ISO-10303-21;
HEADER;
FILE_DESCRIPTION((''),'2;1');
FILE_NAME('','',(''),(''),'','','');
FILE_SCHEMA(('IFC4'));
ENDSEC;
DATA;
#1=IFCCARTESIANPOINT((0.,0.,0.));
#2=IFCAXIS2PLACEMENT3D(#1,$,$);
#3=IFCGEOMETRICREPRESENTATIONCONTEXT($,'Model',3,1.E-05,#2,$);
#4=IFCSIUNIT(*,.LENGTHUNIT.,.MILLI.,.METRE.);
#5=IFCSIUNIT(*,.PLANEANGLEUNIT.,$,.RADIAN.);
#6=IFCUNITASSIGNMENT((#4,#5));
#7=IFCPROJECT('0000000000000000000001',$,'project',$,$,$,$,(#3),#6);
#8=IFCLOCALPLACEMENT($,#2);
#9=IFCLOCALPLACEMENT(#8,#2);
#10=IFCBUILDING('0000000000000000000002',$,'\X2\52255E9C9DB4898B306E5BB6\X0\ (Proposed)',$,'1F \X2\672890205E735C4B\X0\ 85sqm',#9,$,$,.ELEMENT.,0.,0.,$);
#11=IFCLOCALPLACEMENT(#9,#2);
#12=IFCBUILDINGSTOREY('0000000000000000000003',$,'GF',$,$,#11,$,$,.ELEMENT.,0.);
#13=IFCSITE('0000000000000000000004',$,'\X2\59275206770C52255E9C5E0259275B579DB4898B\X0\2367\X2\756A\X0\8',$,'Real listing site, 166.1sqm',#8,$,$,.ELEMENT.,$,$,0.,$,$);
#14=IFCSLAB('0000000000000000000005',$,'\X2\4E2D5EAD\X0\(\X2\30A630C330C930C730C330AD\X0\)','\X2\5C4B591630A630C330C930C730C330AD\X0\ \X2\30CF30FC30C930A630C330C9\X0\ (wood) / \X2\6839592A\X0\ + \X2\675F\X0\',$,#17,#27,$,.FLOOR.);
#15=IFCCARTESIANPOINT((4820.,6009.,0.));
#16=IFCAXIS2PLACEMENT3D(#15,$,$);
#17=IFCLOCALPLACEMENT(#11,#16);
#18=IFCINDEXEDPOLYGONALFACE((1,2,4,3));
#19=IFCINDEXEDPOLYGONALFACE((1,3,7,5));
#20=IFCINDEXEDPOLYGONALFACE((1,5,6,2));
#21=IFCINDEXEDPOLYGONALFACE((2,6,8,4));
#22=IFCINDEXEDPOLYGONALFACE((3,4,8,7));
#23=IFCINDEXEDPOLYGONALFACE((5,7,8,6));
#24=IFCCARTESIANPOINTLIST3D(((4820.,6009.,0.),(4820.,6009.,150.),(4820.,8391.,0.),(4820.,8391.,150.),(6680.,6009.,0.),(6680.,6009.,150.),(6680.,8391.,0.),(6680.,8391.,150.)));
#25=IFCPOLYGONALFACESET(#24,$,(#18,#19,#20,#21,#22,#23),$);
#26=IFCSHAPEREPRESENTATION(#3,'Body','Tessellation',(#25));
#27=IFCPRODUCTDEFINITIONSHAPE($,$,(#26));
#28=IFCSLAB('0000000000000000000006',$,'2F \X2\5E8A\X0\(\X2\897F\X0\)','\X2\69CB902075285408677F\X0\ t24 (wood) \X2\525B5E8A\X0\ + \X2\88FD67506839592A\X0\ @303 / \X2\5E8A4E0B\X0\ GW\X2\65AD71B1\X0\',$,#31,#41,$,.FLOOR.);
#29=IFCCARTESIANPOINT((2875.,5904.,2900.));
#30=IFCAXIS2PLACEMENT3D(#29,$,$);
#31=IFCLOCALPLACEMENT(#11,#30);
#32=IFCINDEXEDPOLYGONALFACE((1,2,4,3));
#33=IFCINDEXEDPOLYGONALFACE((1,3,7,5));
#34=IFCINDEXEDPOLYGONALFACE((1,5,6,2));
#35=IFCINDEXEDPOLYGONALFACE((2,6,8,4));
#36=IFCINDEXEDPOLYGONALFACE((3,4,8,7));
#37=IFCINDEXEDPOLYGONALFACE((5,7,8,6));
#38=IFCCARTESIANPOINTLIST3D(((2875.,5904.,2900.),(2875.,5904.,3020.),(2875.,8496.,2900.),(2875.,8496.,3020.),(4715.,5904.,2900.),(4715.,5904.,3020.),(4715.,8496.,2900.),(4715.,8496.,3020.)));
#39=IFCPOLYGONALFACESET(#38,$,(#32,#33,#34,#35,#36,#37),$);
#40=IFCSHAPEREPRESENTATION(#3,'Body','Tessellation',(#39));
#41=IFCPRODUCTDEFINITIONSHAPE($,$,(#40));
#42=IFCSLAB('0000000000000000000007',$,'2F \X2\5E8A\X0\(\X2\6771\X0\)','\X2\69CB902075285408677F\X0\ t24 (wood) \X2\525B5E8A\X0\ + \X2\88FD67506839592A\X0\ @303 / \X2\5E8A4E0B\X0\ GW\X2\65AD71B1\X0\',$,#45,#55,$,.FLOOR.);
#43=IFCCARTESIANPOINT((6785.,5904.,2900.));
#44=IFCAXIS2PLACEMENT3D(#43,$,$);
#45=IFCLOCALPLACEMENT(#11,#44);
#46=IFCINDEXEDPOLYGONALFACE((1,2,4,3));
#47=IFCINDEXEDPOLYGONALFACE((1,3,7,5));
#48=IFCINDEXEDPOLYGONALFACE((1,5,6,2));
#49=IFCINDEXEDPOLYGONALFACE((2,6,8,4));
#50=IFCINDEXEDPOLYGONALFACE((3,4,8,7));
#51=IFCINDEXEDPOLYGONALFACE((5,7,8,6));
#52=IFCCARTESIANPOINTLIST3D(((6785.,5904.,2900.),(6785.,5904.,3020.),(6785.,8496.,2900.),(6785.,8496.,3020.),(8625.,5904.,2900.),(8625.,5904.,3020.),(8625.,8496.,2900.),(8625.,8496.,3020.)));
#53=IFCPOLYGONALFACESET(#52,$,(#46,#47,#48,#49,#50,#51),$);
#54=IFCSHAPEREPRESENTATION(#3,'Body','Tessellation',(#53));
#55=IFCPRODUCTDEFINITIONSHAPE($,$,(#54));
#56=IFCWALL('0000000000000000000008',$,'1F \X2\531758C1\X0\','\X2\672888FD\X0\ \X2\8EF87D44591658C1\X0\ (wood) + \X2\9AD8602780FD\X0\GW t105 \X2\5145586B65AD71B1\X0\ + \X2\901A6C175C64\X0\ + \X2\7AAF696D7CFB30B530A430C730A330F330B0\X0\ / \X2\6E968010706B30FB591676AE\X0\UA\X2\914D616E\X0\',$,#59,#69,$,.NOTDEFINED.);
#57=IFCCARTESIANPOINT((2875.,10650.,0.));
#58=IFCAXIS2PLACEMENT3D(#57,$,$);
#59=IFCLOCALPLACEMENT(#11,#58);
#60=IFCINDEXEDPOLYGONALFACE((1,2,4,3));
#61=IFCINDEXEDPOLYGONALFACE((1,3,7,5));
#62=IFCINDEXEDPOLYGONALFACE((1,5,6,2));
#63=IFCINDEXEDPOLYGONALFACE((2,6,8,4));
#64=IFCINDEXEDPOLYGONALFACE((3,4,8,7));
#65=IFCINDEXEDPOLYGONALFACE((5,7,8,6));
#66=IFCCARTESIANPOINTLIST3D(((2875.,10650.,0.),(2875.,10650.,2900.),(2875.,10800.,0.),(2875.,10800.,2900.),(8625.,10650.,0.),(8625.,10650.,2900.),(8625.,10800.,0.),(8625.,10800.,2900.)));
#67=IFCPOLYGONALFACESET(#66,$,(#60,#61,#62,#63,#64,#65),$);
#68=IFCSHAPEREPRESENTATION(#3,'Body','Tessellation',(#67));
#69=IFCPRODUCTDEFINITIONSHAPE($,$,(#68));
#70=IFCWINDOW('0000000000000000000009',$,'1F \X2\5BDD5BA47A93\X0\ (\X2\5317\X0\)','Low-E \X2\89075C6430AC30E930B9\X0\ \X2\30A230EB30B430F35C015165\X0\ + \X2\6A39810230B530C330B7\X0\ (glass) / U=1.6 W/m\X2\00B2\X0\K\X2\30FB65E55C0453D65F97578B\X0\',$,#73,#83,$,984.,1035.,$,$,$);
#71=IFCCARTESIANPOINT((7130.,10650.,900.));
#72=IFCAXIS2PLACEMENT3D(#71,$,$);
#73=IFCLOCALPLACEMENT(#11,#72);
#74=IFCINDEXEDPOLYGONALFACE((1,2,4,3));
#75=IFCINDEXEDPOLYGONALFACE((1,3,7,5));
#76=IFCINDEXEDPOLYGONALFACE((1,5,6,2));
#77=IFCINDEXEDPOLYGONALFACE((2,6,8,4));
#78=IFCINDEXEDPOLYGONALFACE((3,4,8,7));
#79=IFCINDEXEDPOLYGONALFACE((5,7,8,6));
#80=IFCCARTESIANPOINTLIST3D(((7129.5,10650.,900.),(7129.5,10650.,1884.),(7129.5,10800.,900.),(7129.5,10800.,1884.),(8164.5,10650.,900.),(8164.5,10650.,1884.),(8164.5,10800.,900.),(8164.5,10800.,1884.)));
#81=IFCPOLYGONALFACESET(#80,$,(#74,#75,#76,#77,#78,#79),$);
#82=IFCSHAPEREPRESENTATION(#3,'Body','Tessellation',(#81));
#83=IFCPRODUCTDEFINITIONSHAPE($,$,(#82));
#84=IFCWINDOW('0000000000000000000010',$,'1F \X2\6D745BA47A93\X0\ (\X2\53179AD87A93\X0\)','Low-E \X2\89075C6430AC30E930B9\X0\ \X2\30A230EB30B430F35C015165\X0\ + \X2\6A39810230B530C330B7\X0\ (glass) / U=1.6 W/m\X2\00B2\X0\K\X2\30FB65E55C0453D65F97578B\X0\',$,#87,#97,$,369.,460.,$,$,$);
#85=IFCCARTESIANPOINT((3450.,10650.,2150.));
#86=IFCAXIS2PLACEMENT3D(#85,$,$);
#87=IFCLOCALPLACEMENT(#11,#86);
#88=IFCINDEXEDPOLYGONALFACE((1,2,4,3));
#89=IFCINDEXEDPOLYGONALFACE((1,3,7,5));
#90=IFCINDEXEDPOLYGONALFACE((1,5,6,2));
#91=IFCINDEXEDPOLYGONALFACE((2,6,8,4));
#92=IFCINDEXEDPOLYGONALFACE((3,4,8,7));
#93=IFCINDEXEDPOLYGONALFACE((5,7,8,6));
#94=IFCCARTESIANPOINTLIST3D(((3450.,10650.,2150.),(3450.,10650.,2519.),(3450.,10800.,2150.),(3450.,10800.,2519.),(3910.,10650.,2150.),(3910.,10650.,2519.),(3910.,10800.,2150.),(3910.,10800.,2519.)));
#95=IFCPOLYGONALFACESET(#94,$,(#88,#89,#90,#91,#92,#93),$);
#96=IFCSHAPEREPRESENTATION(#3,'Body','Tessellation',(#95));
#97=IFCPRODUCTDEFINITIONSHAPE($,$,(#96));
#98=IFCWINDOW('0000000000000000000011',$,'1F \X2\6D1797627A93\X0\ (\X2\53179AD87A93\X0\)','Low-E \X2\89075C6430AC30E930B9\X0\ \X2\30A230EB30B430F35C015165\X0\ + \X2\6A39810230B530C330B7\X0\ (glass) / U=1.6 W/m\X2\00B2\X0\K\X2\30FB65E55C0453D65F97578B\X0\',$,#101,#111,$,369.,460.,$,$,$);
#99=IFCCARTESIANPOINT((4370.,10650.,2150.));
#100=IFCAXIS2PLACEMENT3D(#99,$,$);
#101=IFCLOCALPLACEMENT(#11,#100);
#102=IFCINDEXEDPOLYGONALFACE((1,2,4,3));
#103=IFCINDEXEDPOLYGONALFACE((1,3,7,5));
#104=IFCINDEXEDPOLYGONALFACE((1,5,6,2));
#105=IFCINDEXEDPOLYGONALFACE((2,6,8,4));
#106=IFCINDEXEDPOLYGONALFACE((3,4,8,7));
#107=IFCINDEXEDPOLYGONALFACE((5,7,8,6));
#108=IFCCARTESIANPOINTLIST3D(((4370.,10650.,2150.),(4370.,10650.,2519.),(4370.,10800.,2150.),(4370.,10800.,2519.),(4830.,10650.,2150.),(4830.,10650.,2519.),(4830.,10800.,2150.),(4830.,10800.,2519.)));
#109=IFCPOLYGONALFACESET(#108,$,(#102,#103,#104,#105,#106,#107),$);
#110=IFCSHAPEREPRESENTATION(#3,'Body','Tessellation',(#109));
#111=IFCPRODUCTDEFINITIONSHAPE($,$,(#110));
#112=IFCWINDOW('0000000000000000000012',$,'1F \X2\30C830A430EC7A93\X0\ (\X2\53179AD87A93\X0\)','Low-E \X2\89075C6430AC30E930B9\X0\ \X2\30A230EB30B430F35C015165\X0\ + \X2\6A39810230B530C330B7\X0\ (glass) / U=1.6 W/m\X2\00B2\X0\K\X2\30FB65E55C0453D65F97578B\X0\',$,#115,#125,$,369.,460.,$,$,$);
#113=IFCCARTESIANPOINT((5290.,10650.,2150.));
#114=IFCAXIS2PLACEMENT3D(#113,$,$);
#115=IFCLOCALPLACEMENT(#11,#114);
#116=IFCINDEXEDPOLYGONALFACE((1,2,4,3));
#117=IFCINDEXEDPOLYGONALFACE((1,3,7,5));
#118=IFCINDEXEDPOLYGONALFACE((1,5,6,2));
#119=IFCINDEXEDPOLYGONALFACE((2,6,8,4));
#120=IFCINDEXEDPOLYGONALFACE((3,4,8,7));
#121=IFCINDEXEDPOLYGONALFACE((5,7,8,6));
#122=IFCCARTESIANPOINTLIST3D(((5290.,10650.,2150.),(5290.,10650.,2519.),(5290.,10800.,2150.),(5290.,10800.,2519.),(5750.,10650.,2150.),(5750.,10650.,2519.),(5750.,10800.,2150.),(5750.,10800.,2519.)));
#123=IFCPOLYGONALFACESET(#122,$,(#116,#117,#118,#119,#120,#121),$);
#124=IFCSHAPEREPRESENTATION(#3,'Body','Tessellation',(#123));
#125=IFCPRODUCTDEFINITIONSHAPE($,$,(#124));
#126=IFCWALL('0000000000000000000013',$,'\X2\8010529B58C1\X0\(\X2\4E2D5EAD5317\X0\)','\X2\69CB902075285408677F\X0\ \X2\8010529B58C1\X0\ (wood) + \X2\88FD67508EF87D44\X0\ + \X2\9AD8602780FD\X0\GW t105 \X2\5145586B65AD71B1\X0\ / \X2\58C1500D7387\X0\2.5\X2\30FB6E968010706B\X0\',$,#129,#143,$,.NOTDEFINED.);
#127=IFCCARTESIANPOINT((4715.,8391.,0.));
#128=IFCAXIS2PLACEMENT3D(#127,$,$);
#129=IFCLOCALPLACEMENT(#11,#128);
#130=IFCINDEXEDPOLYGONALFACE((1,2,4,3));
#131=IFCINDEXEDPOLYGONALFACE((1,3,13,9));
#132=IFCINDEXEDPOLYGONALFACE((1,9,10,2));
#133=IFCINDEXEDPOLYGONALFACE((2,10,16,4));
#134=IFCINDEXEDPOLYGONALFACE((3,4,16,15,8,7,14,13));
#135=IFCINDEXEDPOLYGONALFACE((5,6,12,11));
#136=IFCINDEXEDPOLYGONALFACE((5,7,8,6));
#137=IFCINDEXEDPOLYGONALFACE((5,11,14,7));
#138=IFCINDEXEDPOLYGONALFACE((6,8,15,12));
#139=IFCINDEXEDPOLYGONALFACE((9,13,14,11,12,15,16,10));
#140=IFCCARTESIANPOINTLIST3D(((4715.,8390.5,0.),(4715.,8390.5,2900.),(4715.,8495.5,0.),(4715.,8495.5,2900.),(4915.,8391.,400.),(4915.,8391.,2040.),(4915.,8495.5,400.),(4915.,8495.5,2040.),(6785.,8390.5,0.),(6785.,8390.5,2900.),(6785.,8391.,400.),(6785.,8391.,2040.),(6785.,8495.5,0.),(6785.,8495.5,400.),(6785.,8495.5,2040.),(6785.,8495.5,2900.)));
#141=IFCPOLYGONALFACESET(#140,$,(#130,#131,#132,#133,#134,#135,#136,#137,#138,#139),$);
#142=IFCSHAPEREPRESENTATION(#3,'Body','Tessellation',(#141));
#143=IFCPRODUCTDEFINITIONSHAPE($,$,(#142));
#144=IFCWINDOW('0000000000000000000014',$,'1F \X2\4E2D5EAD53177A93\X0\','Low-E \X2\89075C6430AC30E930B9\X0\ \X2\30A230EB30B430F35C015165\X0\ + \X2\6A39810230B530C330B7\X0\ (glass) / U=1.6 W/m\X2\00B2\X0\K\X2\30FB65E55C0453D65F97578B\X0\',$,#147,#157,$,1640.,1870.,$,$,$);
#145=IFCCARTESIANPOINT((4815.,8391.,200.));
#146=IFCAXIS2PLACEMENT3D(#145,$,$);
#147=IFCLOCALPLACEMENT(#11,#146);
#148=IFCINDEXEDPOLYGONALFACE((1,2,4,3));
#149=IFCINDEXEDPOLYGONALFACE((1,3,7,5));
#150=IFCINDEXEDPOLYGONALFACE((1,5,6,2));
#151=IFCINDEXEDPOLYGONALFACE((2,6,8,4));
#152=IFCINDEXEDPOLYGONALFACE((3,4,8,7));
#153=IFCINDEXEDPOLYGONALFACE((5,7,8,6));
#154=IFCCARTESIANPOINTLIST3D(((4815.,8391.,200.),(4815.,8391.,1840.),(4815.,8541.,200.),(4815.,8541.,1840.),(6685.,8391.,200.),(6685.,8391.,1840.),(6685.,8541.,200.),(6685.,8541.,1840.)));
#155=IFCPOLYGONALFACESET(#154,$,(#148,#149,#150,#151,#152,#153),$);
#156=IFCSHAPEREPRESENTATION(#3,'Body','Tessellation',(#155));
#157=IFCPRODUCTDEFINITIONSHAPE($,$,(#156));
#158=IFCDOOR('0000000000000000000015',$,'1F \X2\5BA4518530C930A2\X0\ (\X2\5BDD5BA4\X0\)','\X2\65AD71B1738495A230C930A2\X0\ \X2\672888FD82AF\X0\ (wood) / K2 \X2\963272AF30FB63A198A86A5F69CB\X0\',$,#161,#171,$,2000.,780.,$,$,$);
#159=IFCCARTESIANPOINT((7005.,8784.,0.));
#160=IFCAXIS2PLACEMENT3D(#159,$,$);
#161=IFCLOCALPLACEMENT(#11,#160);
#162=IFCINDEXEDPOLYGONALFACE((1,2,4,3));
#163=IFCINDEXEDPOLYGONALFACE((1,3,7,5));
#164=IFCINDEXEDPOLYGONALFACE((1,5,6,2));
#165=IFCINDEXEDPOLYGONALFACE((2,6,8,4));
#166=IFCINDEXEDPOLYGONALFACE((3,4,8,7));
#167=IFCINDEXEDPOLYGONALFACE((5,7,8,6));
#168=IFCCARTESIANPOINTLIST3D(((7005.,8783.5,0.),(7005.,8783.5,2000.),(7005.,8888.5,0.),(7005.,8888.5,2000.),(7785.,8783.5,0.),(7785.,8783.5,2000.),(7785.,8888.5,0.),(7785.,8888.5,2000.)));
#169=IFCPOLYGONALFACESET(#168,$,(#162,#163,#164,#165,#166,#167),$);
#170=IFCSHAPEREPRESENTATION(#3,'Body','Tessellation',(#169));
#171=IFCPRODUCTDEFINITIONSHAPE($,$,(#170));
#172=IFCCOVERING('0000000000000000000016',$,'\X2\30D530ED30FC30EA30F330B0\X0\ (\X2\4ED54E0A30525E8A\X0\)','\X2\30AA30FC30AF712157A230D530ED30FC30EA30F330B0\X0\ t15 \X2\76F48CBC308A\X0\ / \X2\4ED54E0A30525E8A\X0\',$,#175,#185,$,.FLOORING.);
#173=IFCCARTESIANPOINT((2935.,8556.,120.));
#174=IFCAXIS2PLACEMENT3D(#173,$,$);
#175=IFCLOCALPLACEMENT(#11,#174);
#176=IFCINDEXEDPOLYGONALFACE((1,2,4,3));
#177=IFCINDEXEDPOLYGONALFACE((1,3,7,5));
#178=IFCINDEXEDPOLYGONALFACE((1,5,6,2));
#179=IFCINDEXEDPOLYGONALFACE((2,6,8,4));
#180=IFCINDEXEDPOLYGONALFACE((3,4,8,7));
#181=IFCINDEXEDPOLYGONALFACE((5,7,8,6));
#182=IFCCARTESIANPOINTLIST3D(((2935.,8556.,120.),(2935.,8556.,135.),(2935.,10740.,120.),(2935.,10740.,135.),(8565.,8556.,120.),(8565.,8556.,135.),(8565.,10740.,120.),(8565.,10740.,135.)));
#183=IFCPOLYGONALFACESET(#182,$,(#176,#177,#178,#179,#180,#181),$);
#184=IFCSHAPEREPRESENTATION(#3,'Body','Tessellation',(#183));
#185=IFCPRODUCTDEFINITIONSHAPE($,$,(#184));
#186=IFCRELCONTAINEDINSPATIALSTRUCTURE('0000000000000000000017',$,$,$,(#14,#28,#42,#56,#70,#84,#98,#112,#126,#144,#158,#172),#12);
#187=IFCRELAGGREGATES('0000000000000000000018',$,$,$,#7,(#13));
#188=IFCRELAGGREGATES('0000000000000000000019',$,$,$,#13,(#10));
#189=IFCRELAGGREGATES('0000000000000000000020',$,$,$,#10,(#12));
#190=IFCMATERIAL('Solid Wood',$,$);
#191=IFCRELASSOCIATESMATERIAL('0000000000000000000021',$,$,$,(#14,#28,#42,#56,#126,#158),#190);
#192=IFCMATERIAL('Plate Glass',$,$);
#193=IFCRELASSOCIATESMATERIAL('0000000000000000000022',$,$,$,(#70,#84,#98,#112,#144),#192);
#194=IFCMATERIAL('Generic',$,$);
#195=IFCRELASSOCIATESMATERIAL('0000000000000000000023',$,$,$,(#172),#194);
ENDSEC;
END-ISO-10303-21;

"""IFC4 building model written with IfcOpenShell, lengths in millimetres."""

from ifc_helpers import new_model, si_unit, frame, frame_2d, origin, place, context, project, spatial, rectangle, extrude, material, element, fill, save


model = new_model("IFC4")

# Units and contexts
model_context = context("Model", 3, precision=1e-05, world=origin())
ifc_project = project(units=[si_unit("LENGTHUNIT", "METRE", prefix="MILLI"), si_unit("PLANEANGLEUNIT", "RADIAN")], contexts=[model_context])

# Site, building, storey
site_placement = place(None, origin())
site = spatial("IfcSite", under=ifc_project, at=site_placement, Name="大分県別府市大字鶴見2367番8", ObjectType="Real listing site, 166.1sqm", CompositionType="ELEMENT", RefElevation=0.0)
building_placement = place(site_placement, origin())
building = spatial("IfcBuilding", under=site, at=building_placement, Name="別府鶴見の家 (Proposed)", ObjectType="1F 木造平屋 85sqm", CompositionType="ELEMENT", ElevationOfRefHeight=0.0, ElevationOfTerrain=0.0)
storey_placement = place(building_placement, origin())
storey = spatial("IfcBuildingStorey", under=building, at=storey_placement, Name="GF", CompositionType="ELEMENT", Elevation=0.0)

# Slabs
ifc_material_1 = material(Name="Solid Wood")
slab_1_placement = place(storey_placement, frame((4820.0, 6009.0, 0.0)))
element("IfcSlab", 1, at=slab_1_placement, inside=storey, material=ifc_material_1, Name="中庭(ウッドデッキ)", Description="屋外ウッドデッキ ハードウッド (wood) / 根太 + 束", PredefinedType="FLOOR", context=model_context, shape_type="SweptSolid", body=[
    extrude(rectangle(XDim=1860.0, YDim=2382.0, at=frame_2d((930.0, 1191.0))), frame((4820.0, 6009.0, 0.0)), (0.0, 0.0, 1.0), 150.0),
])
slab_2_placement = place(storey_placement, frame((2875.0, 5904.0, 2900.0)))
element("IfcSlab", 2, at=slab_2_placement, inside=storey, material=ifc_material_1, Name="2F 床(西)", Description="構造用合板 t24 (wood) 剛床 + 製材根太 @303 / 床下 GW断熱", PredefinedType="FLOOR", context=model_context, shape_type="SweptSolid", body=[
    extrude(rectangle(XDim=1840.0, YDim=2592.0, at=frame_2d((920.0, 1296.0))), frame((2875.0, 5904.0, 2900.0)), (0.0, 0.0, 1.0), 120.0),
])
slab_3_placement = place(storey_placement, frame((6785.0, 5904.0, 2900.0)))
element("IfcSlab", 3, at=slab_3_placement, inside=storey, material=ifc_material_1, Name="2F 床(東)", Description="構造用合板 t24 (wood) 剛床 + 製材根太 @303 / 床下 GW断熱", PredefinedType="FLOOR", context=model_context, shape_type="SweptSolid", body=[
    extrude(rectangle(XDim=1840.0, YDim=2592.0, at=frame_2d((920.0, 1296.0))), frame((6785.0, 5904.0, 2900.0)), (0.0, 0.0, 1.0), 120.0),
])

# Wall, openings, windows
wall_1_placement = place(storey_placement, frame((2875.0, 10650.0, 0.0)))
wall_1 = element("IfcWall", 4, at=wall_1_placement, inside=storey, material=ifc_material_1, Name="1F 北壁", Description="木製 軸組外壁 (wood) + 高性能GW t105 充填断熱 + 通気層 + 窯業系サイディング / 準耐火・外皮UA配慮", PredefinedType="NOTDEFINED", context=model_context, shape_type="SweptSolid", body=[
    extrude(rectangle(XDim=5750.0, YDim=150.0, at=frame_2d((2875.0, 75.0))), frame((2875.0, 10650.0, 0.0)), (0.0, 0.0, 1.0), 2900.0),
])
opening_1_placement = place(storey_placement, frame((7130.0, 10650.0, 900.0)))
opening_1 = element("IfcOpeningElement", 5, at=opening_1_placement, cuts=wall_1, PredefinedType="NOTDEFINED", context=model_context, shape_type="SweptSolid", body=[
    extrude(rectangle(XDim=1035.0, YDim=150.0, at=frame_2d((517.0, 75.0))), frame((7130.0, 10650.0, 900.0)), (0.0, 0.0, 1.0), 984.0),
])
opening_2_placement = place(storey_placement, frame((3450.0, 10650.0, 2150.0)))
opening_2 = element("IfcOpeningElement", 6, at=opening_2_placement, cuts=wall_1, PredefinedType="NOTDEFINED", context=model_context, shape_type="SweptSolid", body=[
    extrude(rectangle(XDim=460.0, YDim=150.0, at=frame_2d((230.0, 75.0))), frame((3450.0, 10650.0, 2150.0)), (0.0, 0.0, 1.0), 369.0),
])
opening_3_placement = place(storey_placement, frame((4370.0, 10650.0, 2150.0)))
opening_3 = element("IfcOpeningElement", 7, at=opening_3_placement, cuts=wall_1, PredefinedType="NOTDEFINED", context=model_context, shape_type="SweptSolid", body=[
    extrude(rectangle(XDim=460.0, YDim=150.0, at=frame_2d((230.0, 75.0))), frame((4370.0, 10650.0, 2150.0)), (0.0, 0.0, 1.0), 369.0),
])
opening_4_placement = place(storey_placement, frame((5290.0, 10650.0, 2150.0)))
opening_4 = element("IfcOpeningElement", 8, at=opening_4_placement, cuts=wall_1, PredefinedType="NOTDEFINED", context=model_context, shape_type="SweptSolid", body=[
    extrude(rectangle(XDim=460.0, YDim=150.0, at=frame_2d((230.0, 75.0))), frame((5290.0, 10650.0, 2150.0)), (0.0, 0.0, 1.0), 369.0),
])
ifc_material_2 = material(Name="Plate Glass")
window_1_placement = place(storey_placement, frame((7130.0, 10650.0, 900.0)))
window_1 = element("IfcWindow", 9, at=window_1_placement, inside=storey, material=ifc_material_2, Name="1F 寝室窓 (北)", Description="Low-E 複層ガラス アルゴン封入 + 樹脂サッシ (glass) / U=1.6 W/m²K・日射取得型", OverallHeight=984.0, OverallWidth=1035.0, context=model_context, shape_type="SweptSolid", body=[
    extrude(rectangle(XDim=1035.0, YDim=150.0, at=frame_2d((517.0, 75.0))), frame((7130.0, 10650.0, 900.0)), (0.0, 0.0, 1.0), 984.0),
])
fill(opening_1, window_1)
window_2_placement = place(storey_placement, frame((3450.0, 10650.0, 2150.0)))
window_2 = element("IfcWindow", 10, at=window_2_placement, inside=storey, material=ifc_material_2, Name="1F 浴室窓 (北高窓)", Description="Low-E 複層ガラス アルゴン封入 + 樹脂サッシ (glass) / U=1.6 W/m²K・日射取得型", OverallHeight=369.0, OverallWidth=460.0, context=model_context, shape_type="SweptSolid", body=[
    extrude(rectangle(XDim=460.0, YDim=150.0, at=frame_2d((230.0, 75.0))), frame((3450.0, 10650.0, 2150.0)), (0.0, 0.0, 1.0), 369.0),
])
fill(opening_2, window_2)
window_3_placement = place(storey_placement, frame((4370.0, 10650.0, 2150.0)))
window_3 = element("IfcWindow", 11, at=window_3_placement, inside=storey, material=ifc_material_2, Name="1F 洗面窓 (北高窓)", Description="Low-E 複層ガラス アルゴン封入 + 樹脂サッシ (glass) / U=1.6 W/m²K・日射取得型", OverallHeight=369.0, OverallWidth=460.0, context=model_context, shape_type="SweptSolid", body=[
    extrude(rectangle(XDim=460.0, YDim=150.0, at=frame_2d((230.0, 75.0))), frame((4370.0, 10650.0, 2150.0)), (0.0, 0.0, 1.0), 369.0),
])
fill(opening_3, window_3)
window_4_placement = place(storey_placement, frame((5290.0, 10650.0, 2150.0)))
window_4 = element("IfcWindow", 12, at=window_4_placement, inside=storey, material=ifc_material_2, Name="1F トイレ窓 (北高窓)", Description="Low-E 複層ガラス アルゴン封入 + 樹脂サッシ (glass) / U=1.6 W/m²K・日射取得型", OverallHeight=369.0, OverallWidth=460.0, context=model_context, shape_type="SweptSolid", body=[
    extrude(rectangle(XDim=460.0, YDim=150.0, at=frame_2d((230.0, 75.0))), frame((5290.0, 10650.0, 2150.0)), (0.0, 0.0, 1.0), 369.0),
])
fill(opening_4, window_4)

# Wall, opening, window
wall_2_placement = place(storey_placement, frame((4715.0, 8391.0, 0.0)))
wall_2 = element("IfcWall", 13, at=wall_2_placement, inside=storey, material=ifc_material_1, Name="耐力壁(中庭北)", Description="構造用合板 耐力壁 (wood) + 製材軸組 + 高性能GW t105 充填断熱 / 壁倍率2.5・準耐火", PredefinedType="NOTDEFINED", context=model_context, shape_type="SweptSolid", body=[
    extrude(rectangle(XDim=2070.0, YDim=105.0, at=frame_2d((1035.0, 52.0))), frame((4715.0, 8391.0, 0.0)), (0.0, 0.0, 1.0), 2900.0),
])
opening_5_placement = place(storey_placement, frame((4815.0, 8391.0, 200.0)))
opening_5 = element("IfcOpeningElement", 14, at=opening_5_placement, cuts=wall_2, PredefinedType="NOTDEFINED", context=model_context, shape_type="SweptSolid", body=[
    extrude(rectangle(XDim=1870.0, YDim=150.0, at=frame_2d((935.0, 75.0))), frame((4815.0, 8391.0, 200.0)), (0.0, 0.0, 1.0), 1640.0),
])
window_5_placement = place(storey_placement, frame((4815.0, 8391.0, 200.0)))
window_5 = element("IfcWindow", 15, at=window_5_placement, inside=storey, material=ifc_material_2, Name="1F 中庭北窓", Description="Low-E 複層ガラス アルゴン封入 + 樹脂サッシ (glass) / U=1.6 W/m²K・日射取得型", OverallHeight=1640.0, OverallWidth=1870.0, context=model_context, shape_type="SweptSolid", body=[
    extrude(rectangle(XDim=1870.0, YDim=150.0, at=frame_2d((935.0, 75.0))), frame((4815.0, 8391.0, 200.0)), (0.0, 0.0, 1.0), 1640.0),
])
fill(opening_5, window_5)

# Door
door_1_placement = place(storey_placement, frame((7005.0, 8784.0, 0.0)))
element("IfcDoor", 16, at=door_1_placement, inside=storey, material=ifc_material_1, Name="1F 室内ドア (寝室)", Description="断熱玄関ドア 木製芯 (wood) / K2 防犯・採風機構", OverallHeight=2000.0, OverallWidth=780.0, context=model_context, shape_type="SweptSolid", body=[
    extrude(rectangle(XDim=780.0, YDim=105.0, at=frame_2d((390.0, 52.0))), frame((7005.0, 8784.0, 0.0)), (0.0, 0.0, 1.0), 2000.0),
])

# Covering
ifc_material_3 = material(Name="Generic")
covering_1_placement = place(storey_placement, frame((2935.0, 8556.0, 120.0)))
element("IfcCovering", 17, at=covering_1_placement, inside=storey, material=ifc_material_3, Name="フローリング (仕上げ床)", Description="オーク無垢フローリング t15 直貼り / 仕上げ床", PredefinedType="FLOORING", context=model_context, shape_type="SweptSolid", body=[
    extrude(rectangle(XDim=5630.0, YDim=2184.0, at=frame_2d((2815.0, 1092.0))), frame((2935.0, 8556.0, 120.0)), (0.0, 0.0, 1.0), 15.0),
])

save(model, "model.ifc")
